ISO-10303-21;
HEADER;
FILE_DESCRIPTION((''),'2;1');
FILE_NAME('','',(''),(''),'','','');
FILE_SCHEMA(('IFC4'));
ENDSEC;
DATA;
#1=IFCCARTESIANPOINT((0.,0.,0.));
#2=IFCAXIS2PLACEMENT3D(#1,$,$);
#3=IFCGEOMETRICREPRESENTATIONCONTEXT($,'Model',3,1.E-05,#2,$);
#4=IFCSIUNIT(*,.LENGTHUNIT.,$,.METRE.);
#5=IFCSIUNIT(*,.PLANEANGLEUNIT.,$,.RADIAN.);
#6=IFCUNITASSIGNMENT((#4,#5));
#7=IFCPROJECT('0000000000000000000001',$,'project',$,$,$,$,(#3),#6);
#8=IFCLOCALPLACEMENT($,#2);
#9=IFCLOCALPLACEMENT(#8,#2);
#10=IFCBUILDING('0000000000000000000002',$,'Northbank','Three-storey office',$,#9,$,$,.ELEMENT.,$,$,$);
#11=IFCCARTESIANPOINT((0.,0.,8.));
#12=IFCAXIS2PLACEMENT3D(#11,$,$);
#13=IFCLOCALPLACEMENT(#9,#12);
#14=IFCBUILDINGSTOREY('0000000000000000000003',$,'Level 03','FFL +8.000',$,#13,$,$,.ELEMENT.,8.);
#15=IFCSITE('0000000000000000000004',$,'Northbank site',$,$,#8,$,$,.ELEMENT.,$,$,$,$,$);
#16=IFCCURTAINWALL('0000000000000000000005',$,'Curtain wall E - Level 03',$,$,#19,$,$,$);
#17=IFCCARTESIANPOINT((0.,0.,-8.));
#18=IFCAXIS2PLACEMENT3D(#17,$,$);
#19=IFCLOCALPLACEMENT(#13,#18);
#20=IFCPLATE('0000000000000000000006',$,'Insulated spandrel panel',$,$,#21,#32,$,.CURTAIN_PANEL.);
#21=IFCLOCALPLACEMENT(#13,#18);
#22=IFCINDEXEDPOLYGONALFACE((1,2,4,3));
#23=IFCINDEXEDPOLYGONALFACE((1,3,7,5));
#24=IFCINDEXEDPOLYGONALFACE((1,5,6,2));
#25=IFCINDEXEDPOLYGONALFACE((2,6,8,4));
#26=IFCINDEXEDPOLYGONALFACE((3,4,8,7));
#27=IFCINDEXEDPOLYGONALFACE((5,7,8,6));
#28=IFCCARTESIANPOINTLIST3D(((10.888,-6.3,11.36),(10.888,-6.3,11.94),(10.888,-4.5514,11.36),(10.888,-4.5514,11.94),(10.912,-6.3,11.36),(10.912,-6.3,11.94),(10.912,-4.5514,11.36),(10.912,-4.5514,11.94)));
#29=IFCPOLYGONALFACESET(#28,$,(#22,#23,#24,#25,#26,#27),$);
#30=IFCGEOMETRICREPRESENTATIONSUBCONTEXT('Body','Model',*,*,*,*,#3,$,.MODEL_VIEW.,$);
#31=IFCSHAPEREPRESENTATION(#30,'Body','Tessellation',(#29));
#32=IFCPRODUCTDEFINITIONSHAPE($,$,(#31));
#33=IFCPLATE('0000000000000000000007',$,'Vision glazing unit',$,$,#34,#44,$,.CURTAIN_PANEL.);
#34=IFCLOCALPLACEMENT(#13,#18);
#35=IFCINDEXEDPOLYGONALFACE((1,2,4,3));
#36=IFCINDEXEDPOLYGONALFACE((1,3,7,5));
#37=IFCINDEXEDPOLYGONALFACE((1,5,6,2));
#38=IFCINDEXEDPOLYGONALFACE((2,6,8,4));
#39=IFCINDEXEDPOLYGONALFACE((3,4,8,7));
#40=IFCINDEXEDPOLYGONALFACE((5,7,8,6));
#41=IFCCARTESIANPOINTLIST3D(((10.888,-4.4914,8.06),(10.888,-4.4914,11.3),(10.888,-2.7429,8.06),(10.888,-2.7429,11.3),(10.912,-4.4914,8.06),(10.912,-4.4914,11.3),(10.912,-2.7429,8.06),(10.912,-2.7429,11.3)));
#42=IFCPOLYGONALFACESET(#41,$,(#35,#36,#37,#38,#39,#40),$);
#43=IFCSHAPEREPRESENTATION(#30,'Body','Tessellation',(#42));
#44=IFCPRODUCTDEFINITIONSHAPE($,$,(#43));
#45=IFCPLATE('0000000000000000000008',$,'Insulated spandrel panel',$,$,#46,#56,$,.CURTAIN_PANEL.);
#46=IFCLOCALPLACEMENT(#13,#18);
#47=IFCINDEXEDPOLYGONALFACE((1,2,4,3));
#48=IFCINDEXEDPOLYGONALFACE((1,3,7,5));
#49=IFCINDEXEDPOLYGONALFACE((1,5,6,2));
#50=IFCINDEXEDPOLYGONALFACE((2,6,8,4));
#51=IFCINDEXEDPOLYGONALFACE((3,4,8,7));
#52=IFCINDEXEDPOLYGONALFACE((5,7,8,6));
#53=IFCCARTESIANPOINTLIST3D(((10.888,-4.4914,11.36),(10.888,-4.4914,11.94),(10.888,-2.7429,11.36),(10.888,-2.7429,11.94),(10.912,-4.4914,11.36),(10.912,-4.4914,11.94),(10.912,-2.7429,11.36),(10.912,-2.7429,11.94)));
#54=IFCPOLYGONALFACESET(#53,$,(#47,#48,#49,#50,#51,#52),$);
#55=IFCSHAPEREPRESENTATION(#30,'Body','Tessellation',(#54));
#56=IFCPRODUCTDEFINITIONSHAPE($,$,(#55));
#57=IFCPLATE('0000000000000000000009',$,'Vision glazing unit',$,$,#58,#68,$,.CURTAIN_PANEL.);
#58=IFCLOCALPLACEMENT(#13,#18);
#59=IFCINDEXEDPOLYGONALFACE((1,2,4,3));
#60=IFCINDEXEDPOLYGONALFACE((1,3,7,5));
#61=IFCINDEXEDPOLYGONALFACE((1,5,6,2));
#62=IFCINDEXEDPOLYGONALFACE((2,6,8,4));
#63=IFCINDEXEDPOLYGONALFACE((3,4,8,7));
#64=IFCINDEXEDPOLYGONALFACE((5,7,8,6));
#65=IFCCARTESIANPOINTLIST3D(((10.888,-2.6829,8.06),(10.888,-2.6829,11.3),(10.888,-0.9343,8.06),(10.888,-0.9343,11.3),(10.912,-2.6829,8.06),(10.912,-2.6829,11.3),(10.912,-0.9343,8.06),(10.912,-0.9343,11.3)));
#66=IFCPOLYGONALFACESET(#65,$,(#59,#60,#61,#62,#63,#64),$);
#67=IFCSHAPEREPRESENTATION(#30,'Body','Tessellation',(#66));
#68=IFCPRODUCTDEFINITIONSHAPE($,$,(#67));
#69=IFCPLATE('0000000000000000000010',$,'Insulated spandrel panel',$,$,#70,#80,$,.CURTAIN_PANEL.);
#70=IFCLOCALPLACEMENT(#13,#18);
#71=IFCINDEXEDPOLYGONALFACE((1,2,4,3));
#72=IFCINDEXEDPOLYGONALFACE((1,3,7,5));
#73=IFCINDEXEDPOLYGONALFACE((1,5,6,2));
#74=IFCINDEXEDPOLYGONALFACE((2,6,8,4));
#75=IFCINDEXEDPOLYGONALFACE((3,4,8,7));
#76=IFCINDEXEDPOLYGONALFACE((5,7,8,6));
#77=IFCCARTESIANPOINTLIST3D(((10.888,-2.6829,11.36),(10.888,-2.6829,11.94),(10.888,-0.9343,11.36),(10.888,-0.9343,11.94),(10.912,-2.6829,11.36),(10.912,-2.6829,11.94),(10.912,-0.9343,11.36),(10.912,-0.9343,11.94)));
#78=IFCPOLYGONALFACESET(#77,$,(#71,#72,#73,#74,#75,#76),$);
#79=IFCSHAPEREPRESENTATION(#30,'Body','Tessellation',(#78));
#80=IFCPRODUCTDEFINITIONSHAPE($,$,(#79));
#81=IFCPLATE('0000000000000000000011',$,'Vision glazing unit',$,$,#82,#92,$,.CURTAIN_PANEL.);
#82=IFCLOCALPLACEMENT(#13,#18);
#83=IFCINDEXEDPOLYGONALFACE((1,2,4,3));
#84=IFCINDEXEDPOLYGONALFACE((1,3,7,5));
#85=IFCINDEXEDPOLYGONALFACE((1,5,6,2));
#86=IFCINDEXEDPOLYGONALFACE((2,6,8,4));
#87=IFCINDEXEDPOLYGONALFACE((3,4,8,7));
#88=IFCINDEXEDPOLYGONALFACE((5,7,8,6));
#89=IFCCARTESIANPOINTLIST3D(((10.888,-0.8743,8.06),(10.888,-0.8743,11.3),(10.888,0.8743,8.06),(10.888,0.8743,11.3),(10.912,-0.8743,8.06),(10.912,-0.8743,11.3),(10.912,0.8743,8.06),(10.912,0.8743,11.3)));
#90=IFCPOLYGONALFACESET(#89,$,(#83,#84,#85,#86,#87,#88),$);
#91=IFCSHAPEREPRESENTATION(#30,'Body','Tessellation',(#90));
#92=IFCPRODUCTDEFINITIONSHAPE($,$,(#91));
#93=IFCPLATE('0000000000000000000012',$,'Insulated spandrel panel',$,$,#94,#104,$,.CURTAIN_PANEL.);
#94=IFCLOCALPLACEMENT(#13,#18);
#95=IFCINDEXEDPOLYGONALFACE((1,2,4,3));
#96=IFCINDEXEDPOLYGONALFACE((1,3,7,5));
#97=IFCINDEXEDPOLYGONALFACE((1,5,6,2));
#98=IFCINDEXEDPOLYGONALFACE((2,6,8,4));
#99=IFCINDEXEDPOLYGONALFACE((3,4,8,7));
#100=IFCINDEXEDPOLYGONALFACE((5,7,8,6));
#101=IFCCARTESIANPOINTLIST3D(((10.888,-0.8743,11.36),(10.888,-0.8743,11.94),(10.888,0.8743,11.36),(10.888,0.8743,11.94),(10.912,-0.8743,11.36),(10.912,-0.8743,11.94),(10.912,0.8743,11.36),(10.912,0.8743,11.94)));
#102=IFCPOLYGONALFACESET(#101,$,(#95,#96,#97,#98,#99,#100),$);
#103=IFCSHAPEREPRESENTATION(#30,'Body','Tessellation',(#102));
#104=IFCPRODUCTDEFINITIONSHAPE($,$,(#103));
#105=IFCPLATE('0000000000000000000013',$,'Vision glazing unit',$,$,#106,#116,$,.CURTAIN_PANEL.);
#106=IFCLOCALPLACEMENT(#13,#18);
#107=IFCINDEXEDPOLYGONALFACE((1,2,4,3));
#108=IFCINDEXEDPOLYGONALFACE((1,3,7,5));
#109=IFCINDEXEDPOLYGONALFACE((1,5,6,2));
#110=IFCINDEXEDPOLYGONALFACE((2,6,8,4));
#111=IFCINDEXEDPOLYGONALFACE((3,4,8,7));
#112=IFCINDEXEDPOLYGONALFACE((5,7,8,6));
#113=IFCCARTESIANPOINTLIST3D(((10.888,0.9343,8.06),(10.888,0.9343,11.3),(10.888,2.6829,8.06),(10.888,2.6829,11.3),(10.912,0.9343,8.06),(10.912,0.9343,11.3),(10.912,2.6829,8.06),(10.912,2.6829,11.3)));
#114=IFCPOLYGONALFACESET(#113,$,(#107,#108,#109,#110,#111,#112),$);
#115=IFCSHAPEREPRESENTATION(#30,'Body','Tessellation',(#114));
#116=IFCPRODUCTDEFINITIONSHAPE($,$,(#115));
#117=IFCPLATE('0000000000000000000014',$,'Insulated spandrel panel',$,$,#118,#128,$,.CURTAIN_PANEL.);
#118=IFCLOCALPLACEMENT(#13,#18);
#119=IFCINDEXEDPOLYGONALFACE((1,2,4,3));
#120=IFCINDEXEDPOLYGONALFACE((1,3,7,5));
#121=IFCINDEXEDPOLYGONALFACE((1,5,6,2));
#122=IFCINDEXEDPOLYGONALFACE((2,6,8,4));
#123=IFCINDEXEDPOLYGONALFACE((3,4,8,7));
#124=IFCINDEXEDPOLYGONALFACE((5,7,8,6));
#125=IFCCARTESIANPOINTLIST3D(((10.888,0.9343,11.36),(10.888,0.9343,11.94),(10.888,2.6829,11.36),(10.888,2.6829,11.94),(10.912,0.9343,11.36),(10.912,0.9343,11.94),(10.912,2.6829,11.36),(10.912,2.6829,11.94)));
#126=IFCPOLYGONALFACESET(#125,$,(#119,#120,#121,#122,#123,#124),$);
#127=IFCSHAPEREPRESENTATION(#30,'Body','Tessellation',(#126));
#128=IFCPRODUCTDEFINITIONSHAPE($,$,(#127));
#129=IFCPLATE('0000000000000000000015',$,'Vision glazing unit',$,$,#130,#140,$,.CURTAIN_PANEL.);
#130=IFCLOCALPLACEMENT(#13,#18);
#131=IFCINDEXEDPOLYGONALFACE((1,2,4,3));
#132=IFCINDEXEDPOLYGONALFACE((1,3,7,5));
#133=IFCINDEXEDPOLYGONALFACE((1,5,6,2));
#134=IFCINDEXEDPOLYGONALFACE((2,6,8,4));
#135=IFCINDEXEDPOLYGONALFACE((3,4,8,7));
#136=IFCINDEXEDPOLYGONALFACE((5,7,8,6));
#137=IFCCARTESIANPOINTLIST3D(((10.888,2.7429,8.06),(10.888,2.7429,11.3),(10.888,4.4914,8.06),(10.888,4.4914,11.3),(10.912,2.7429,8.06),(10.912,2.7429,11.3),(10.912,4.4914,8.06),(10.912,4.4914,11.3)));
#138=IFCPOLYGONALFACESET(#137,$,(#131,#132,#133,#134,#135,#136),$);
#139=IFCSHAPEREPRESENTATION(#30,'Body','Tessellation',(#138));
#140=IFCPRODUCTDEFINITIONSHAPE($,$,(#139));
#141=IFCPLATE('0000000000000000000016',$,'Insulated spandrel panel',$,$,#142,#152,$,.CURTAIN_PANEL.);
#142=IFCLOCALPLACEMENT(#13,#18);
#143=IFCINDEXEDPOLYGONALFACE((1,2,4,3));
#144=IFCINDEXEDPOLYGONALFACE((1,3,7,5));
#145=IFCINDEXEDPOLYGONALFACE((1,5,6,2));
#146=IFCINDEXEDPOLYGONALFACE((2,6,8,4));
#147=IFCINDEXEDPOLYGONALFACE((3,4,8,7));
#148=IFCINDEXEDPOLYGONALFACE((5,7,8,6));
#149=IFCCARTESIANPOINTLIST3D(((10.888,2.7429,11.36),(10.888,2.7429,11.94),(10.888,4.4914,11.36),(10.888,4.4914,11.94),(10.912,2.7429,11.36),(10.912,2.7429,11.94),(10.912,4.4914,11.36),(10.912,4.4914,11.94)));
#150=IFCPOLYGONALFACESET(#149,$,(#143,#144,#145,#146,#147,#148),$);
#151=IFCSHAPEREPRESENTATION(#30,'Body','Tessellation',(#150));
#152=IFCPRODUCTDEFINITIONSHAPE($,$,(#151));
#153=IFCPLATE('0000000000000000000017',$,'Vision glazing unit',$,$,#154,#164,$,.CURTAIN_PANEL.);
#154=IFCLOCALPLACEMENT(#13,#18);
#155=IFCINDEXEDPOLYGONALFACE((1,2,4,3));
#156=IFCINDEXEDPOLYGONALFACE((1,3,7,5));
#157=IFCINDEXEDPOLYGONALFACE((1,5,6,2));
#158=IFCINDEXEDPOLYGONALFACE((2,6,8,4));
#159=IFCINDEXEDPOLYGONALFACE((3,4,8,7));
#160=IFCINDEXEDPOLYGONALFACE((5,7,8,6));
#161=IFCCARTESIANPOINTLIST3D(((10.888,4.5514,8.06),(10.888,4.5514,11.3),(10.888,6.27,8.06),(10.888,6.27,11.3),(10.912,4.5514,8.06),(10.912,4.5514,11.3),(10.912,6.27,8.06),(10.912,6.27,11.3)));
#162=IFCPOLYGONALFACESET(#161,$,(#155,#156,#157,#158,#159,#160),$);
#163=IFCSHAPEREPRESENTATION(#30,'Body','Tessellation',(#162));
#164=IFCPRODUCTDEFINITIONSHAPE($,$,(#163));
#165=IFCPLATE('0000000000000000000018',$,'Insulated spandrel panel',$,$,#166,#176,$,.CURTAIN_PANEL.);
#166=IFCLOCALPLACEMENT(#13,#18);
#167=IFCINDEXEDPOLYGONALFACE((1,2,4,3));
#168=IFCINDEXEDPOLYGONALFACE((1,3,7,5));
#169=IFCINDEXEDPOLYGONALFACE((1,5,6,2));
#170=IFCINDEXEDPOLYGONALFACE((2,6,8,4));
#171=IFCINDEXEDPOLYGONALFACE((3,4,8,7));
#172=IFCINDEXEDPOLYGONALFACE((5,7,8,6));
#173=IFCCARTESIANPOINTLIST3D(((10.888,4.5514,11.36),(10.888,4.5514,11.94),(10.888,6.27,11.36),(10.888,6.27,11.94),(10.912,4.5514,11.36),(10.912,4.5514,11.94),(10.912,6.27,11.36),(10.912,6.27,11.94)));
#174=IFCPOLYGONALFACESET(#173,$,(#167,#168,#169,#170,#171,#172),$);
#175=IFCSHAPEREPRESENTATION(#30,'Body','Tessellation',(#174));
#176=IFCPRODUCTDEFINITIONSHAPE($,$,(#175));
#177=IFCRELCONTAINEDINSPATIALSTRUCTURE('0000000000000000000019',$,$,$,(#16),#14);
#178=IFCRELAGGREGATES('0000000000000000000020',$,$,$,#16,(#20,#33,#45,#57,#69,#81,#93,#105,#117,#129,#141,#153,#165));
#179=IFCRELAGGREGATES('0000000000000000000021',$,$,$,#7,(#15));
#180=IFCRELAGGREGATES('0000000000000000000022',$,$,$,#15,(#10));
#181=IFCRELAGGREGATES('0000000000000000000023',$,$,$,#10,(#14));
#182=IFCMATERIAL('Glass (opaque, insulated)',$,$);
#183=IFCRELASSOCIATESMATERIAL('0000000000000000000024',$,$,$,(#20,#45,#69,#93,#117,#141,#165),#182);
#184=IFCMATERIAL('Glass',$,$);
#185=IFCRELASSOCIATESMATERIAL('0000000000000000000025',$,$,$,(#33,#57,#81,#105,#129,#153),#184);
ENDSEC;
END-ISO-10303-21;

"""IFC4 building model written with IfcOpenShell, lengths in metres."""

from ifc_helpers import new_model, si_unit, frame, origin, place, context, subcontext, project, spatial, rectangle, extrude, material, element, aggregate, save


model = new_model("IFC4")

# Units and contexts
model_context = context("Model", 3, precision=1e-05, world=origin())
body_context = subcontext(model_context, "Body", "Model", "MODEL_VIEW")
ifc_project = project(units=[si_unit("LENGTHUNIT", "METRE"), si_unit("PLANEANGLEUNIT", "RADIAN")], contexts=[model_context])

# Site, building, storey
site_placement = place(None, origin())
site = spatial("IfcSite", under=ifc_project, at=site_placement, Name="Northbank site", CompositionType="ELEMENT")
building_placement = place(site_placement, origin())
building = spatial("IfcBuilding", under=site, at=building_placement, Name="Northbank", Description="Three-storey office", CompositionType="ELEMENT")
storey_placement = place(building_placement, frame((0.0, 0.0, 8.0)))
storey = spatial("IfcBuildingStorey", under=building, at=storey_placement, Name="Level 03", Description="FFL +8.000", CompositionType="ELEMENT", Elevation=8.0)

# Curtain wall, plates
curtain_wall_placement = place(storey_placement, frame((0.0, 0.0, -8.0)))
curtain_wall = element("IfcCurtainWall", 1, at=curtain_wall_placement, inside=storey, Name="Curtain wall E - Level 03")
ifc_material_1 = material(Name="Glass")
ifc_material_2 = material(Name="Glass (opaque, insulated)")
plate_1_placement = place(storey_placement, frame((0.0, 0.0, -8.0)))
plate_1 = element("IfcPlate", 2, at=plate_1_placement, material=ifc_material_2, Name="Insulated spandrel panel", PredefinedType="CURTAIN_PANEL", context=body_context, shape_type="SweptSolid", body=[
    extrude(rectangle(XDim=0.024, YDim=1.7486), frame((10.9, -5.4257, 11.36)), (0.0, 0.0, 1.0), 0.58),
])
plate_2_placement = place(storey_placement, frame((0.0, 0.0, -8.0)))
plate_2 = element("IfcPlate", 3, at=plate_2_placement, material=ifc_material_1, Name="Vision glazing unit", PredefinedType="CURTAIN_PANEL", context=body_context, shape_type="SweptSolid", body=[
    extrude(rectangle(XDim=0.024, YDim=1.7486), frame((10.9, -3.6171, 8.06)), (0.0, 0.0, 1.0), 3.24),
])
plate_3_placement = place(storey_placement, frame((0.0, 0.0, -8.0)))
plate_3 = element("IfcPlate", 4, at=plate_3_placement, material=ifc_material_2, Name="Insulated spandrel panel", PredefinedType="CURTAIN_PANEL", context=body_context, shape_type="SweptSolid", body=[
    extrude(rectangle(XDim=0.024, YDim=1.7486), frame((10.9, -3.6171, 11.36)), (0.0, 0.0, 1.0), 0.58),
])
plate_4_placement = place(storey_placement, frame((0.0, 0.0, -8.0)))
plate_4 = element("IfcPlate", 5, at=plate_4_placement, material=ifc_material_1, Name="Vision glazing unit", PredefinedType="CURTAIN_PANEL", context=body_context, shape_type="SweptSolid", body=[
    extrude(rectangle(XDim=0.024, YDim=1.7486), frame((10.9, -1.8086, 8.06)), (0.0, 0.0, 1.0), 3.24),
])
plate_5_placement = place(storey_placement, frame((0.0, 0.0, -8.0)))
plate_5 = element("IfcPlate", 6, at=plate_5_placement, material=ifc_material_2, Name="Insulated spandrel panel", PredefinedType="CURTAIN_PANEL", context=body_context, shape_type="SweptSolid", body=[
    extrude(rectangle(XDim=0.024, YDim=1.7486), frame((10.9, -1.8086, 11.36)), (0.0, 0.0, 1.0), 0.58),
])
plate_6_placement = place(storey_placement, frame((0.0, 0.0, -8.0)))
plate_6 = element("IfcPlate", 7, at=plate_6_placement, material=ifc_material_1, Name="Vision glazing unit", PredefinedType="CURTAIN_PANEL", context=body_context, shape_type="SweptSolid", body=[
    extrude(rectangle(XDim=0.024, YDim=1.7486), frame((10.9, 0.0, 8.06)), (0.0, 0.0, 1.0), 3.24),
])
plate_7_placement = place(storey_placement, frame((0.0, 0.0, -8.0)))
plate_7 = element("IfcPlate", 8, at=plate_7_placement, material=ifc_material_2, Name="Insulated spandrel panel", PredefinedType="CURTAIN_PANEL", context=body_context, shape_type="SweptSolid", body=[
    extrude(rectangle(XDim=0.024, YDim=1.7486), frame((10.9, 0.0, 11.36)), (0.0, 0.0, 1.0), 0.58),
])
plate_8_placement = place(storey_placement, frame((0.0, 0.0, -8.0)))
plate_8 = element("IfcPlate", 9, at=plate_8_placement, material=ifc_material_1, Name="Vision glazing unit", PredefinedType="CURTAIN_PANEL", context=body_context, shape_type="SweptSolid", body=[
    extrude(rectangle(XDim=0.024, YDim=1.7486), frame((10.9, 1.8086, 8.06)), (0.0, 0.0, 1.0), 3.24),
])
plate_9_placement = place(storey_placement, frame((0.0, 0.0, -8.0)))
plate_9 = element("IfcPlate", 10, at=plate_9_placement, material=ifc_material_2, Name="Insulated spandrel panel", PredefinedType="CURTAIN_PANEL", context=body_context, shape_type="SweptSolid", body=[
    extrude(rectangle(XDim=0.024, YDim=1.7486), frame((10.9, 1.8086, 11.36)), (0.0, 0.0, 1.0), 0.58),
])
plate_10_placement = place(storey_placement, frame((0.0, 0.0, -8.0)))
plate_10 = element("IfcPlate", 11, at=plate_10_placement, material=ifc_material_1, Name="Vision glazing unit", PredefinedType="CURTAIN_PANEL", context=body_context, shape_type="SweptSolid", body=[
    extrude(rectangle(XDim=0.024, YDim=1.7486), frame((10.9, 3.6171, 8.06)), (0.0, 0.0, 1.0), 3.24),
])
plate_11_placement = place(storey_placement, frame((0.0, 0.0, -8.0)))
plate_11 = element("IfcPlate", 12, at=plate_11_placement, material=ifc_material_2, Name="Insulated spandrel panel", PredefinedType="CURTAIN_PANEL", context=body_context, shape_type="SweptSolid", body=[
    extrude(rectangle(XDim=0.024, YDim=1.7486), frame((10.9, 3.6171, 11.36)), (0.0, 0.0, 1.0), 0.58),
])
plate_12_placement = place(storey_placement, frame((0.0, 0.0, -8.0)))
plate_12 = element("IfcPlate", 13, at=plate_12_placement, material=ifc_material_1, Name="Vision glazing unit", PredefinedType="CURTAIN_PANEL", context=body_context, shape_type="SweptSolid", body=[
    extrude(rectangle(XDim=0.024, YDim=1.7186), frame((10.9, 5.4107, 8.06)), (0.0, 0.0, 1.0), 3.24),
])
plate_13_placement = place(storey_placement, frame((0.0, 0.0, -8.0)))
plate_13 = element("IfcPlate", 14, at=plate_13_placement, material=ifc_material_2, Name="Insulated spandrel panel", PredefinedType="CURTAIN_PANEL", context=body_context, shape_type="SweptSolid", body=[
    extrude(rectangle(XDim=0.024, YDim=1.7186), frame((10.9, 5.4107, 11.36)), (0.0, 0.0, 1.0), 0.58),
])
aggregate(curtain_wall, [plate_1, plate_2, plate_3, plate_4, plate_5, plate_6, plate_7, plate_8, plate_9, plate_10, plate_11, plate_12, plate_13])

save(model, "model.ifc")
